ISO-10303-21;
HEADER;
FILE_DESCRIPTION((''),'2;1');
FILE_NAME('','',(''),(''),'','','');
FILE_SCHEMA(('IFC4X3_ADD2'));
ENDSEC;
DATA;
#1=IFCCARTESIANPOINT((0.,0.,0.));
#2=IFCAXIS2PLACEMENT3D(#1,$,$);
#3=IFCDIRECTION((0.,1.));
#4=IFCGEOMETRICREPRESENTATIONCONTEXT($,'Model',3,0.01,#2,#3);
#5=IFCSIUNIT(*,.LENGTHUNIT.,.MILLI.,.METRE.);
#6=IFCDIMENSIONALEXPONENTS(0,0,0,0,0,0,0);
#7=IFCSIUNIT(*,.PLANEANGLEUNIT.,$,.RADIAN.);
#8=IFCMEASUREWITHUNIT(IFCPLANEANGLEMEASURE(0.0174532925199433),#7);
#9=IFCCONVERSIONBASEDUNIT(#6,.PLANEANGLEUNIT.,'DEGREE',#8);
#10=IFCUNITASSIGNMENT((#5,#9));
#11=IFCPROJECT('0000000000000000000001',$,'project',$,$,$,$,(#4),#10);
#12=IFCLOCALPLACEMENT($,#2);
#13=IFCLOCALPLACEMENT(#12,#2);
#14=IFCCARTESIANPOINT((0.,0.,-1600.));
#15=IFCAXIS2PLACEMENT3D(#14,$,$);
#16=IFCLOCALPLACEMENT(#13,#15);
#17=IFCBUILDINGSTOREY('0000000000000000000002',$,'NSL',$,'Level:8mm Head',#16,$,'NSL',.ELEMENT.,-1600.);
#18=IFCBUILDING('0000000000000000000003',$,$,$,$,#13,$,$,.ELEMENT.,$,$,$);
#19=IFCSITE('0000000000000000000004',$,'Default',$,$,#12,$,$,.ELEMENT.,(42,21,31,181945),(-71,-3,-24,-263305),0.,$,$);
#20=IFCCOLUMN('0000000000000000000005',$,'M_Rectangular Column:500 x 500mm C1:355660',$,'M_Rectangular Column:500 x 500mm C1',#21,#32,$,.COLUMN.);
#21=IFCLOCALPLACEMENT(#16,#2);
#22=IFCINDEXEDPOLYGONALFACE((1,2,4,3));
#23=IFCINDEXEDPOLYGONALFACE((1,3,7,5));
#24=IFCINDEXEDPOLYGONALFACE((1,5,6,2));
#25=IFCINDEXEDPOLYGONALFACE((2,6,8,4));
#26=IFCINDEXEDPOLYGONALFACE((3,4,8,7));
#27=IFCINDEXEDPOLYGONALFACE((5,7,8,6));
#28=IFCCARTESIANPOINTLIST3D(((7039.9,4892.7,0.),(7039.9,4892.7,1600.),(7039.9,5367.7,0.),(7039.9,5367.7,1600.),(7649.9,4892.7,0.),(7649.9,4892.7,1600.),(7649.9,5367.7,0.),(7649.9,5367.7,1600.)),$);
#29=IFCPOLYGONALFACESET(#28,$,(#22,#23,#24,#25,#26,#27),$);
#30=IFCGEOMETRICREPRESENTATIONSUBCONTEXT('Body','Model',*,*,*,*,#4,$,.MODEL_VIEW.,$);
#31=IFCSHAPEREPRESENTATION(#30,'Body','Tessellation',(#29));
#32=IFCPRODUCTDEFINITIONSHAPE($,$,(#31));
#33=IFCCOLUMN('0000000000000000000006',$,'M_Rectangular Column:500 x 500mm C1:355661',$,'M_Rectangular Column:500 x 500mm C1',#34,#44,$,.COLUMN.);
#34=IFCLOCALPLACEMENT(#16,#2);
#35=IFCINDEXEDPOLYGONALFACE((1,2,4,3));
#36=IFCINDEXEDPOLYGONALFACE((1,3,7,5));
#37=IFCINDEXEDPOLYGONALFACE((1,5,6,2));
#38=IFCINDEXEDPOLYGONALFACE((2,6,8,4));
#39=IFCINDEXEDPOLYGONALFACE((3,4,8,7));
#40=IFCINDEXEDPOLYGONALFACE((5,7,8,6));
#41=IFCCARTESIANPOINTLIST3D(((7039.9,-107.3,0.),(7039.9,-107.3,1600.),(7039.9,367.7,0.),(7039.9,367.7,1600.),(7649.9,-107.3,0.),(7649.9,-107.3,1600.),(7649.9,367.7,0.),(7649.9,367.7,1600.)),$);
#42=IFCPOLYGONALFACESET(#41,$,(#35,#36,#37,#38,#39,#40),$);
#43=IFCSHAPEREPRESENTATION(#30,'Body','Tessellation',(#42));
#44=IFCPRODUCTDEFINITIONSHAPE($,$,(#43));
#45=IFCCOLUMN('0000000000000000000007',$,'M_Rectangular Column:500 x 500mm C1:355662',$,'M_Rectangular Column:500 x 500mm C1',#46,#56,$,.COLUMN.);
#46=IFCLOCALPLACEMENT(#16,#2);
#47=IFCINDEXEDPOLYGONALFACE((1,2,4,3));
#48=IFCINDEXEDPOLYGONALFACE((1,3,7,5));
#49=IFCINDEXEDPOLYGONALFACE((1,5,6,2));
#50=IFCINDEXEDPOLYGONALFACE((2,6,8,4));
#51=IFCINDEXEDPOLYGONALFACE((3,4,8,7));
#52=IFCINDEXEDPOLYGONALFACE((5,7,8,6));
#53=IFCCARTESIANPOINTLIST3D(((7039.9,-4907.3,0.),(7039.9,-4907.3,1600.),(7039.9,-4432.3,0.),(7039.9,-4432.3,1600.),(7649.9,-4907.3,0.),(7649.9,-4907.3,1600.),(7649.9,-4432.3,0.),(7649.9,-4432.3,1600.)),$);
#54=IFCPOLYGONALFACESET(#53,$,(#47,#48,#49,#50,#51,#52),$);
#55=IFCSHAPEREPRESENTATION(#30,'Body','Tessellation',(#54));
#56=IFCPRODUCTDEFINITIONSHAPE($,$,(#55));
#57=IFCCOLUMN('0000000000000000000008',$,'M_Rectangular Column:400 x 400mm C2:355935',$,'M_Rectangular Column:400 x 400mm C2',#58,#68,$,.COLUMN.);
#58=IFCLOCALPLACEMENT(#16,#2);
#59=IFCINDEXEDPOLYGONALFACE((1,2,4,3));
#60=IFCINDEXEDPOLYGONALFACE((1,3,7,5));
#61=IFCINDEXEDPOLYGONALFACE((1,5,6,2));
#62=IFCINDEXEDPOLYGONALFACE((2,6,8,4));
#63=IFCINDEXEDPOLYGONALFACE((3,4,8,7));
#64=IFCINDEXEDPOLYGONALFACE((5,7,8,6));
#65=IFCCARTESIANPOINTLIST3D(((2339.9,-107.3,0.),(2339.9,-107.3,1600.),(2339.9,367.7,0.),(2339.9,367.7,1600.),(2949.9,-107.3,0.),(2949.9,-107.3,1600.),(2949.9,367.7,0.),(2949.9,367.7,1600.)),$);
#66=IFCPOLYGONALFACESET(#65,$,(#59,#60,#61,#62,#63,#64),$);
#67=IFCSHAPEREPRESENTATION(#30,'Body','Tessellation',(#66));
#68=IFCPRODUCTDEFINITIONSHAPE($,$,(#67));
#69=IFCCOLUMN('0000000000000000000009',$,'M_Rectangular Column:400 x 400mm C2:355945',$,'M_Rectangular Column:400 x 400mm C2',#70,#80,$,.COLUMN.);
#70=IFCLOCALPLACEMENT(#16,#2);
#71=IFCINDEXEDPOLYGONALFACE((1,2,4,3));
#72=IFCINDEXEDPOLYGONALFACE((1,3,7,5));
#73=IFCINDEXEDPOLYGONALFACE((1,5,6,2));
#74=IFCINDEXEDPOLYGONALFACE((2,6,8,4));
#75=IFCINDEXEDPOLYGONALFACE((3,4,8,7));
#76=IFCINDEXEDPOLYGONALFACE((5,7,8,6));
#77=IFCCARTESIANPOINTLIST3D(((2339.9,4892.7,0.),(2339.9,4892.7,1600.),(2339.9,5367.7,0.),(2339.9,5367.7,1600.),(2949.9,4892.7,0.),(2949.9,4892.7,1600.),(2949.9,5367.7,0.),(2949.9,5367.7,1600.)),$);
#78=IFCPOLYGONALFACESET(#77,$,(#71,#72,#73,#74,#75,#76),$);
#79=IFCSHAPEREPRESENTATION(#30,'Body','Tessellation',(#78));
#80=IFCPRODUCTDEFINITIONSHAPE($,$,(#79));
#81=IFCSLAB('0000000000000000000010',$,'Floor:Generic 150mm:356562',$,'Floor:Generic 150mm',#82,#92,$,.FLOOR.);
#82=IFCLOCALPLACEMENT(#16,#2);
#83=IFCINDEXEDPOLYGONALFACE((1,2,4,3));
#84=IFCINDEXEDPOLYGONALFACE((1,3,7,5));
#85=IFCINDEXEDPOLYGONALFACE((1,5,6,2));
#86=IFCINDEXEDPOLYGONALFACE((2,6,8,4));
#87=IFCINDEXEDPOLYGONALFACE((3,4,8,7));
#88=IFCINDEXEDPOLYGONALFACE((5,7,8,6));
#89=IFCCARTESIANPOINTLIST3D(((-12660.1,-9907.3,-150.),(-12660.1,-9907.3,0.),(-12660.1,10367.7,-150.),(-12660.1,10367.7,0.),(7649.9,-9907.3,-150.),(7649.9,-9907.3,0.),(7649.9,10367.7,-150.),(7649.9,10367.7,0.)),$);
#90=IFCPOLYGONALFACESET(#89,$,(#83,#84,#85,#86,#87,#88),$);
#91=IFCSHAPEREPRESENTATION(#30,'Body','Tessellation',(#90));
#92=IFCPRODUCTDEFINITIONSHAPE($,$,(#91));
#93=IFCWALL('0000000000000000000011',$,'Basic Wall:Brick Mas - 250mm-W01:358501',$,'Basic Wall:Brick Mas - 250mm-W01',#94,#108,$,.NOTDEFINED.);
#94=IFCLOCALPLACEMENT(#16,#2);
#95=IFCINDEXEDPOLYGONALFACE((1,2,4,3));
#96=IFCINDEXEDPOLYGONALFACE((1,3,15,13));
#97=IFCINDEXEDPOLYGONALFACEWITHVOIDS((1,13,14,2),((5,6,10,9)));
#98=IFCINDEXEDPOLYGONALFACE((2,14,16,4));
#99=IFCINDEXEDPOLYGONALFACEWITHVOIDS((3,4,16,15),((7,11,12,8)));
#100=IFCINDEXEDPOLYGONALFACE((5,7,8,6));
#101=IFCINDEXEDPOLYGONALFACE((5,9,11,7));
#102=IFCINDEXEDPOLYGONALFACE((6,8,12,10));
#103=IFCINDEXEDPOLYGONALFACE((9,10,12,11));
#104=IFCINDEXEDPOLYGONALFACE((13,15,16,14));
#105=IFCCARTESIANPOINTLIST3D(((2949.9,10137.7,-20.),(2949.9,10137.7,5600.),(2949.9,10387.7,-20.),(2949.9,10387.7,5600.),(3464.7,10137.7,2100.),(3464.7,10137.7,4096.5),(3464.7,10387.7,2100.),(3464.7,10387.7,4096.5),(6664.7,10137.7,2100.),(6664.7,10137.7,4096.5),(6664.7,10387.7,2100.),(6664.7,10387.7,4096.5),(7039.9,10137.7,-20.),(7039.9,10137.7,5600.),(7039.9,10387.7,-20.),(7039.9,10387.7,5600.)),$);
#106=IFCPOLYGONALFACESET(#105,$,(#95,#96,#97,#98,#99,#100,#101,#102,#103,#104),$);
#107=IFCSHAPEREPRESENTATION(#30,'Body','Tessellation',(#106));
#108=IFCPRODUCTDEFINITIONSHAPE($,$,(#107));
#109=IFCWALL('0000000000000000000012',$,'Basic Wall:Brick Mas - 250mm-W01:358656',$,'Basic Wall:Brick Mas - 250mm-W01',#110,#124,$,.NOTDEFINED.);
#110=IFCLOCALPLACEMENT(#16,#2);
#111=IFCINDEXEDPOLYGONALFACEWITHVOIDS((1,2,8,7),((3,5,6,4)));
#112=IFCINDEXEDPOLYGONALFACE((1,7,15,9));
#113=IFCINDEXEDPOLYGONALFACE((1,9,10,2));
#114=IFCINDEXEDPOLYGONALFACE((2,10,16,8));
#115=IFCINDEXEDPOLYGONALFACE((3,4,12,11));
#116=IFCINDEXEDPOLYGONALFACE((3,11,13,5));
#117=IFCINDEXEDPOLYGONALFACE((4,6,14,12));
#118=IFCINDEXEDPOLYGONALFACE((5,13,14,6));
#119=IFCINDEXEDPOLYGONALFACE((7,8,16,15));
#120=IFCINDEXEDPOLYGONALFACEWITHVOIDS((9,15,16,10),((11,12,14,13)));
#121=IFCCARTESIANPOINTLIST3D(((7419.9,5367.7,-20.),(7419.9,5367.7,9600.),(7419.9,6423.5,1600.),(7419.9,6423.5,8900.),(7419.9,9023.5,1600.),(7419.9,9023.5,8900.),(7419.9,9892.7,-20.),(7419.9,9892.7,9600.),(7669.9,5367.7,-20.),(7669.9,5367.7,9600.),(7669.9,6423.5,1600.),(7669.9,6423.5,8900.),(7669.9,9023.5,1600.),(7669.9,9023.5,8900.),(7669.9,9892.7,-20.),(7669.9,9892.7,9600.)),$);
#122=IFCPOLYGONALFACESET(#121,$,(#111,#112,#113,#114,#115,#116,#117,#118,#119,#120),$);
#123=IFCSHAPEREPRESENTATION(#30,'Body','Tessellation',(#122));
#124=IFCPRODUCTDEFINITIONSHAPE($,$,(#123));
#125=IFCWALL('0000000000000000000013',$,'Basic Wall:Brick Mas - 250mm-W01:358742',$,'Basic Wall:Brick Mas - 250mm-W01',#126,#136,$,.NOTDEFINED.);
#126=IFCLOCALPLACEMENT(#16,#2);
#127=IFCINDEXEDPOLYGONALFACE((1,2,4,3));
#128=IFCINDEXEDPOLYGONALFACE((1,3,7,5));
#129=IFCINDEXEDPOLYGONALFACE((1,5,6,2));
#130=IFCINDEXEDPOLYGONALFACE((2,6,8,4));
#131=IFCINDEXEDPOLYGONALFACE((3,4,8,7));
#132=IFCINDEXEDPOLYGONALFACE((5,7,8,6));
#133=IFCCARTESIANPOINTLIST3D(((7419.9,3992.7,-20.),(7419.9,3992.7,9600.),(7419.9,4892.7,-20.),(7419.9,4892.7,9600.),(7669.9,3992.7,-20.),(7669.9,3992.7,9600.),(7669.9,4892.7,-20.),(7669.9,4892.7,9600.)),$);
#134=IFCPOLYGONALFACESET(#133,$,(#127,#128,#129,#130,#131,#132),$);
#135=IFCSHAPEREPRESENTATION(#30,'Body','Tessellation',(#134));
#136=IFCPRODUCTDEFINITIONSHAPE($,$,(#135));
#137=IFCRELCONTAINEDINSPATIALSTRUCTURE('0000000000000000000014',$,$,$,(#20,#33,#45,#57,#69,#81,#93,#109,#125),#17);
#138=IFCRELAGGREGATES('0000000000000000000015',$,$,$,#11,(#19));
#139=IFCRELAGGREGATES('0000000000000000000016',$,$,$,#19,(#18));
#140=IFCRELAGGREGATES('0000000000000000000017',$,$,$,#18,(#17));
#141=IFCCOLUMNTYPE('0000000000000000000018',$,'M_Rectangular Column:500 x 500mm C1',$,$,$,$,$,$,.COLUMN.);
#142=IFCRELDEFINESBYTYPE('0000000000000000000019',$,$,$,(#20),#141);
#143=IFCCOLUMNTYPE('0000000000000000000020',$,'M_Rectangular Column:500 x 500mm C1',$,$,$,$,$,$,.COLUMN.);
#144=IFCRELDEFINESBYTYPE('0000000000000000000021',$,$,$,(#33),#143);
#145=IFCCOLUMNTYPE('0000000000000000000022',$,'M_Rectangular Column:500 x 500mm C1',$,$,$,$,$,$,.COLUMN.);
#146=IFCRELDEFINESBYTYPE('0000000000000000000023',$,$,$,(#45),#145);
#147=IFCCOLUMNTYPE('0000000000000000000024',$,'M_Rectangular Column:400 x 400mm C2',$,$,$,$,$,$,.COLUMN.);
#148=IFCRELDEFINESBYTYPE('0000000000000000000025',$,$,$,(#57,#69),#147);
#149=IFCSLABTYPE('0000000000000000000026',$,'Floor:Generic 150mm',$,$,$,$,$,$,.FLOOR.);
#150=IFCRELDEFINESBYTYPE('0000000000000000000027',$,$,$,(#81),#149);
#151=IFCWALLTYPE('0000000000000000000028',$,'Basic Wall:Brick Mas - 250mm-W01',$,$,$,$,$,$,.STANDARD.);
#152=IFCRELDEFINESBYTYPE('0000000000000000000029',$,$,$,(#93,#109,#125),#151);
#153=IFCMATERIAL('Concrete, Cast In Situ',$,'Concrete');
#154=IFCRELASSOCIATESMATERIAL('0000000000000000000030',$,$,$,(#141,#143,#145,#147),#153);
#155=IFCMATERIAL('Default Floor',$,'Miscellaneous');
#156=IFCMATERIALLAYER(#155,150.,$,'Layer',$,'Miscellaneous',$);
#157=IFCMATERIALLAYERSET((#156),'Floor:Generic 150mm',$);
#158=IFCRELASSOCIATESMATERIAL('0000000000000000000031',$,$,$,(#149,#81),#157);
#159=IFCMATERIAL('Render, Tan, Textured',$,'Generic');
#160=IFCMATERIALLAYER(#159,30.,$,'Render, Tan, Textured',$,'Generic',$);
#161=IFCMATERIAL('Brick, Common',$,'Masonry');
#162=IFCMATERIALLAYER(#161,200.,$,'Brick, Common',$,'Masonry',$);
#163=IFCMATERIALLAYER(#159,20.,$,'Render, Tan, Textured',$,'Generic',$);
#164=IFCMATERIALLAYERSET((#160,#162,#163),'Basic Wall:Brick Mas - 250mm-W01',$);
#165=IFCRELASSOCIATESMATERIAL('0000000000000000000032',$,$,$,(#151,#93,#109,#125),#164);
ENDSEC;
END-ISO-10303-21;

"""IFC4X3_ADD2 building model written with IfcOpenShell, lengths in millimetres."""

from ifc_helpers import new_model, entity, si_unit, converted_unit, direction, frame, frame_2d, origin, origin_2d_with_axis, place, context, subcontext, project, spatial, rectangle, extrude, source, transform, mapped, material, layer, layer_set, layer_usage, material_profile, profile_set, type_object, type_shapes, element, save


model = new_model("IFC4X3_ADD2")

# Units and contexts
model_context = context("Model", 3, precision=0.01, world=origin(), true_north=direction((0.0, 1.0)))
body_context = subcontext(model_context, "Body", "Model", "MODEL_VIEW")
ifc_project = project(units=[si_unit("LENGTHUNIT", "METRE", prefix="MILLI"), converted_unit("PLANEANGLEUNIT", "DEGREE", entity("IfcPlaneAngleMeasure", 0.0174532925199433), si_unit("PLANEANGLEUNIT", "RADIAN"), dimensions=[0, 0, 0, 0, 0, 0, 0])], contexts=[model_context])

# Site, building, storey
site_placement = place(None, origin())
site = spatial("IfcSite", under=ifc_project, at=site_placement, Name="Default", CompositionType="ELEMENT", RefLatitude=(42, 21, 31, 181945), RefLongitude=(-71, -3, -24, -263305), RefElevation=0.0)
building_placement = place(site_placement, origin())
building = spatial("IfcBuilding", under=site, at=building_placement, CompositionType="ELEMENT")
storey_placement = place(building_placement, frame((0.0, 0.0, -1600.0)))
storey = spatial("IfcBuildingStorey", under=building, at=storey_placement, Name="NSL", ObjectType="Level:8mm Head", LongName="NSL", CompositionType="ELEMENT", Elevation=-1600.0)

# Columns
ifc_material_1 = material(Name="Concrete, Cast In Situ", Category="Concrete")
ifc_material_profile_1 = material_profile(ifc_material_1, rectangle(XDim=610.0, YDim=475.0, at=frame_2d((0.0, 0.0), x_axis=(1.0, 0.0))), Name="500 x 500mm C1")
ifc_profile_set_1 = profile_set([ifc_material_profile_1], Name="500 x 500mm C1")
column_type_1 = type_object("IfcColumnType", Name="M_Rectangular Column:500 x 500mm C1", PredefinedType="COLUMN", material=ifc_profile_set_1)
shared_shape_1 = source(origin(), body_context, "Body", "SweptSolid", [
    extrude(rectangle(XDim=610.0, YDim=475.0, at=frame_2d((0.0, 0.0), x_axis=(1.0, 0.0))), frame((7344.9, 5130.2, -1600.0), z_axis=(0.0, 0.0, 1.0), x_axis=(-1.0, 0.0, 0.0)), (0.0, 0.0, 1.0), 1600.0),
])
type_shapes(column_type_1, [shared_shape_1])
column_1_placement = place(storey_placement, frame((0.0, 0.0, 1600.0)))
element("IfcColumn", 1, at=column_1_placement, inside=storey, type_object=column_type_1, Name="M_Rectangular Column:500 x 500mm C1:355660", ObjectType="M_Rectangular Column:500 x 500mm C1", PredefinedType="COLUMN", context=body_context, shape_type="MappedRepresentation", body=[
    mapped(shared_shape_1, transform((0.0, 0.0, 0.0), scale=1.0)),
])
column_type_2 = type_object("IfcColumnType", Name="M_Rectangular Column:500 x 500mm C1", PredefinedType="COLUMN", material=ifc_profile_set_1)
shared_shape_2 = source(origin(), body_context, "Body", "SweptSolid", [
    extrude(rectangle(XDim=610.0, YDim=475.0, at=origin_2d_with_axis()), frame((7344.9, 130.2, -1600.0), z_axis=(0.0, 0.0, 1.0), x_axis=(-1.0, 0.0, 0.0)), (0.0, 0.0, 1.0), 1600.0),
])
type_shapes(column_type_2, [shared_shape_2])
column_2_placement = place(storey_placement, frame((0.0, 0.0, 1600.0)))
element("IfcColumn", 2, at=column_2_placement, inside=storey, type_object=column_type_2, Name="M_Rectangular Column:500 x 500mm C1:355661", ObjectType="M_Rectangular Column:500 x 500mm C1", PredefinedType="COLUMN", context=body_context, shape_type="MappedRepresentation", body=[
    mapped(shared_shape_2, transform((0.0, 0.0, 0.0), scale=1.0)),
])
column_type_3 = type_object("IfcColumnType", Name="M_Rectangular Column:500 x 500mm C1", PredefinedType="COLUMN", material=ifc_profile_set_1)
shared_shape_3 = source(origin(), body_context, "Body", "SweptSolid", [
    extrude(rectangle(XDim=610.0, YDim=475.0, at=origin_2d_with_axis()), frame((7344.9, -4669.8, -1600.0), z_axis=(0.0, 0.0, 1.0), x_axis=(-1.0, 0.0, 0.0)), (0.0, 0.0, 1.0), 1600.0),
])
type_shapes(column_type_3, [shared_shape_3])
column_3_placement = place(storey_placement, frame((0.0, 0.0, 1600.0)))
element("IfcColumn", 3, at=column_3_placement, inside=storey, type_object=column_type_3, Name="M_Rectangular Column:500 x 500mm C1:355662", ObjectType="M_Rectangular Column:500 x 500mm C1", PredefinedType="COLUMN", context=body_context, shape_type="MappedRepresentation", body=[
    mapped(shared_shape_3, transform((0.0, 0.0, 0.0), scale=1.0)),
])
ifc_material_profile_2 = material_profile(ifc_material_1, rectangle(XDim=610.0, YDim=475.0, at=origin_2d_with_axis()), Name="400 x 400mm C2")
ifc_profile_set_2 = profile_set([ifc_material_profile_2], Name="400 x 400mm C2")
column_type_4 = type_object("IfcColumnType", Name="M_Rectangular Column:400 x 400mm C2", PredefinedType="COLUMN", material=ifc_profile_set_2)
shared_shape_4 = source(origin(), body_context, "Body", "SweptSolid", [
    extrude(rectangle(XDim=610.0, YDim=475.0, at=origin_2d_with_axis()), frame((0.0, 0.0, -1600.0), z_axis=(0.0, 0.0, 1.0), x_axis=(-1.0, 0.0, 0.0)), (0.0, 0.0, 1.0), 1600.0),
])
type_shapes(column_type_4, [shared_shape_4])
for number, where, name in (
    (4, (2644.9, 130.2, 1600.0), "M_Rectangular Column:400 x 400mm C2:355935"),
    (5, (2644.9, 5130.2, 1600.0), "M_Rectangular Column:400 x 400mm C2:355945"),
):
    element("IfcColumn", number, at=place(storey_placement, frame(where)), inside=storey, type_object=column_type_4, Name=name, ObjectType="M_Rectangular Column:400 x 400mm C2", PredefinedType="COLUMN", context=body_context, shape_type="MappedRepresentation", body=[
        mapped(shared_shape_4, transform((0.0, 0.0, 0.0), scale=1.0)),
    ])

# Slab
ifc_material_2 = material(Name="Default Floor", Category="Miscellaneous")
ifc_layer_1 = layer(ifc_material_2, 150.0, Name="Layer", Category="Miscellaneous")
ifc_layer_set_1 = layer_set([ifc_layer_1], Name="Floor:Generic 150mm")
ifc_layer_usage_1 = layer_usage(ifc_layer_set_1, "AXIS3", "POSITIVE", 0.0)
slab_type = type_object("IfcSlabType", Name="Floor:Generic 150mm", PredefinedType="FLOOR", material=ifc_layer_set_1)
slab_placement = place(storey_placement, origin())
element("IfcSlab", 6, at=slab_placement, inside=storey, type_object=slab_type, material=ifc_layer_usage_1, Name="Floor:Generic 150mm:356562", ObjectType="Floor:Generic 150mm", PredefinedType="FLOOR", context=body_context, shape_type="SweptSolid", body=[
    extrude(rectangle(XDim=20275.0, YDim=20310.0, at=origin_2d_with_axis()), frame((-2505.1, 230.2, 0.0), z_axis=(0.0, 0.0, -1.0), x_axis=(0.0, 1.0, 0.0)), (0.0, 0.0, 1.0), 150.0),
])

# Walls, openings
ifc_material_3 = material(Name="Render, Tan, Textured", Category="Generic")
ifc_layer_2 = layer(ifc_material_3, 30.0, Name="Render, Tan, Textured", Category="Generic")
ifc_material_4 = material(Name="Brick, Common", Category="Masonry")
ifc_layer_3 = layer(ifc_material_4, 200.0, Name="Brick, Common", Category="Masonry")
ifc_layer_4 = layer(ifc_material_3, 20.0, Name="Render, Tan, Textured", Category="Generic")
ifc_layer_set_2 = layer_set([ifc_layer_2, ifc_layer_3, ifc_layer_4], Name="Basic Wall:Brick Mas - 250mm-W01")
wall_type = type_object("IfcWallType", Name="Basic Wall:Brick Mas - 250mm-W01", PredefinedType="STANDARD", material=ifc_layer_set_2)
wall_1_placement = place(storey_placement, frame((2949.9, 10262.7, -20.0)))
wall_1 = element("IfcWall", 7, at=wall_1_placement, inside=storey, type_object=wall_type, material=ifc_layer_set_2, Name="Basic Wall:Brick Mas - 250mm-W01:358501", ObjectType="Basic Wall:Brick Mas - 250mm-W01", PredefinedType="NOTDEFINED", context=body_context, shape_type="SweptSolid", body=[
    extrude(rectangle(XDim=4090.0, YDim=250.0, at=frame_2d((2045.0, 0.0), x_axis=(-1.0, 0.0))), origin(), (0.0, 0.0, 1.0), 5620.0),
])
opening_1_placement = place(wall_1_placement, origin())
element("IfcOpeningElement", 8, at=opening_1_placement, cuts=wall_1, PredefinedType="OPENING", context=body_context, shape_type="SweptSolid", body=[
    extrude(rectangle(XDim=1996.5, YDim=3200.0, at=frame_2d((0.0, 0.0), x_axis=(1.0, 0.0))), frame((2114.8, 125.0, 3118.2), z_axis=(0.0, -1.0, 0.0), x_axis=(0.0, 0.0, 1.0)), (0.0, 0.0, 1.0), 250.0),
])
wall_2_placement = place(storey_placement, frame((7544.9, 9892.7, -20.0), z_axis=(0.0, 0.0, 1.0), x_axis=(0.0, -1.0, 0.0)))
wall_2 = element("IfcWall", 9, at=wall_2_placement, inside=storey, type_object=wall_type, material=ifc_layer_set_2, Name="Basic Wall:Brick Mas - 250mm-W01:358656", ObjectType="Basic Wall:Brick Mas - 250mm-W01", PredefinedType="NOTDEFINED", context=body_context, shape_type="SweptSolid", body=[
    extrude(rectangle(XDim=4525.0, YDim=250.0, at=frame_2d((2262.5, 0.0), x_axis=(-1.0, 0.0))), origin(), (0.0, 0.0, 1.0), 9620.0),
])
opening_2_placement = place(wall_2_placement, origin())
element("IfcOpeningElement", 10, at=opening_2_placement, cuts=wall_2, PredefinedType="OPENING", context=body_context, shape_type="SweptSolid", body=[
    extrude(rectangle(XDim=7300.0, YDim=2600.0, at=frame_2d((0.0, 0.0), x_axis=(0.0, 1.0))), frame((2169.2, 125.0, 5270.0), z_axis=(0.0, -1.0, 0.0), x_axis=(1.0, 0.0, 0.0)), (0.0, 0.0, 1.0), 250.0),
])

# Wall
wall_3_placement = place(storey_placement, frame((7544.9, 4892.7, -20.0), z_axis=(0.0, 0.0, 1.0), x_axis=(0.0, -1.0, 0.0)))
element("IfcWall", 11, at=wall_3_placement, inside=storey, type_object=wall_type, material=ifc_layer_set_2, Name="Basic Wall:Brick Mas - 250mm-W01:358742", ObjectType="Basic Wall:Brick Mas - 250mm-W01", PredefinedType="NOTDEFINED", context=body_context, shape_type="SweptSolid", body=[
    extrude(rectangle(XDim=900.0, YDim=250.0, at=frame_2d((450.0, 0.0), x_axis=(-1.0, 0.0))), origin(), (0.0, 0.0, 1.0), 9620.0),
])

save(model, "model.ifc")
